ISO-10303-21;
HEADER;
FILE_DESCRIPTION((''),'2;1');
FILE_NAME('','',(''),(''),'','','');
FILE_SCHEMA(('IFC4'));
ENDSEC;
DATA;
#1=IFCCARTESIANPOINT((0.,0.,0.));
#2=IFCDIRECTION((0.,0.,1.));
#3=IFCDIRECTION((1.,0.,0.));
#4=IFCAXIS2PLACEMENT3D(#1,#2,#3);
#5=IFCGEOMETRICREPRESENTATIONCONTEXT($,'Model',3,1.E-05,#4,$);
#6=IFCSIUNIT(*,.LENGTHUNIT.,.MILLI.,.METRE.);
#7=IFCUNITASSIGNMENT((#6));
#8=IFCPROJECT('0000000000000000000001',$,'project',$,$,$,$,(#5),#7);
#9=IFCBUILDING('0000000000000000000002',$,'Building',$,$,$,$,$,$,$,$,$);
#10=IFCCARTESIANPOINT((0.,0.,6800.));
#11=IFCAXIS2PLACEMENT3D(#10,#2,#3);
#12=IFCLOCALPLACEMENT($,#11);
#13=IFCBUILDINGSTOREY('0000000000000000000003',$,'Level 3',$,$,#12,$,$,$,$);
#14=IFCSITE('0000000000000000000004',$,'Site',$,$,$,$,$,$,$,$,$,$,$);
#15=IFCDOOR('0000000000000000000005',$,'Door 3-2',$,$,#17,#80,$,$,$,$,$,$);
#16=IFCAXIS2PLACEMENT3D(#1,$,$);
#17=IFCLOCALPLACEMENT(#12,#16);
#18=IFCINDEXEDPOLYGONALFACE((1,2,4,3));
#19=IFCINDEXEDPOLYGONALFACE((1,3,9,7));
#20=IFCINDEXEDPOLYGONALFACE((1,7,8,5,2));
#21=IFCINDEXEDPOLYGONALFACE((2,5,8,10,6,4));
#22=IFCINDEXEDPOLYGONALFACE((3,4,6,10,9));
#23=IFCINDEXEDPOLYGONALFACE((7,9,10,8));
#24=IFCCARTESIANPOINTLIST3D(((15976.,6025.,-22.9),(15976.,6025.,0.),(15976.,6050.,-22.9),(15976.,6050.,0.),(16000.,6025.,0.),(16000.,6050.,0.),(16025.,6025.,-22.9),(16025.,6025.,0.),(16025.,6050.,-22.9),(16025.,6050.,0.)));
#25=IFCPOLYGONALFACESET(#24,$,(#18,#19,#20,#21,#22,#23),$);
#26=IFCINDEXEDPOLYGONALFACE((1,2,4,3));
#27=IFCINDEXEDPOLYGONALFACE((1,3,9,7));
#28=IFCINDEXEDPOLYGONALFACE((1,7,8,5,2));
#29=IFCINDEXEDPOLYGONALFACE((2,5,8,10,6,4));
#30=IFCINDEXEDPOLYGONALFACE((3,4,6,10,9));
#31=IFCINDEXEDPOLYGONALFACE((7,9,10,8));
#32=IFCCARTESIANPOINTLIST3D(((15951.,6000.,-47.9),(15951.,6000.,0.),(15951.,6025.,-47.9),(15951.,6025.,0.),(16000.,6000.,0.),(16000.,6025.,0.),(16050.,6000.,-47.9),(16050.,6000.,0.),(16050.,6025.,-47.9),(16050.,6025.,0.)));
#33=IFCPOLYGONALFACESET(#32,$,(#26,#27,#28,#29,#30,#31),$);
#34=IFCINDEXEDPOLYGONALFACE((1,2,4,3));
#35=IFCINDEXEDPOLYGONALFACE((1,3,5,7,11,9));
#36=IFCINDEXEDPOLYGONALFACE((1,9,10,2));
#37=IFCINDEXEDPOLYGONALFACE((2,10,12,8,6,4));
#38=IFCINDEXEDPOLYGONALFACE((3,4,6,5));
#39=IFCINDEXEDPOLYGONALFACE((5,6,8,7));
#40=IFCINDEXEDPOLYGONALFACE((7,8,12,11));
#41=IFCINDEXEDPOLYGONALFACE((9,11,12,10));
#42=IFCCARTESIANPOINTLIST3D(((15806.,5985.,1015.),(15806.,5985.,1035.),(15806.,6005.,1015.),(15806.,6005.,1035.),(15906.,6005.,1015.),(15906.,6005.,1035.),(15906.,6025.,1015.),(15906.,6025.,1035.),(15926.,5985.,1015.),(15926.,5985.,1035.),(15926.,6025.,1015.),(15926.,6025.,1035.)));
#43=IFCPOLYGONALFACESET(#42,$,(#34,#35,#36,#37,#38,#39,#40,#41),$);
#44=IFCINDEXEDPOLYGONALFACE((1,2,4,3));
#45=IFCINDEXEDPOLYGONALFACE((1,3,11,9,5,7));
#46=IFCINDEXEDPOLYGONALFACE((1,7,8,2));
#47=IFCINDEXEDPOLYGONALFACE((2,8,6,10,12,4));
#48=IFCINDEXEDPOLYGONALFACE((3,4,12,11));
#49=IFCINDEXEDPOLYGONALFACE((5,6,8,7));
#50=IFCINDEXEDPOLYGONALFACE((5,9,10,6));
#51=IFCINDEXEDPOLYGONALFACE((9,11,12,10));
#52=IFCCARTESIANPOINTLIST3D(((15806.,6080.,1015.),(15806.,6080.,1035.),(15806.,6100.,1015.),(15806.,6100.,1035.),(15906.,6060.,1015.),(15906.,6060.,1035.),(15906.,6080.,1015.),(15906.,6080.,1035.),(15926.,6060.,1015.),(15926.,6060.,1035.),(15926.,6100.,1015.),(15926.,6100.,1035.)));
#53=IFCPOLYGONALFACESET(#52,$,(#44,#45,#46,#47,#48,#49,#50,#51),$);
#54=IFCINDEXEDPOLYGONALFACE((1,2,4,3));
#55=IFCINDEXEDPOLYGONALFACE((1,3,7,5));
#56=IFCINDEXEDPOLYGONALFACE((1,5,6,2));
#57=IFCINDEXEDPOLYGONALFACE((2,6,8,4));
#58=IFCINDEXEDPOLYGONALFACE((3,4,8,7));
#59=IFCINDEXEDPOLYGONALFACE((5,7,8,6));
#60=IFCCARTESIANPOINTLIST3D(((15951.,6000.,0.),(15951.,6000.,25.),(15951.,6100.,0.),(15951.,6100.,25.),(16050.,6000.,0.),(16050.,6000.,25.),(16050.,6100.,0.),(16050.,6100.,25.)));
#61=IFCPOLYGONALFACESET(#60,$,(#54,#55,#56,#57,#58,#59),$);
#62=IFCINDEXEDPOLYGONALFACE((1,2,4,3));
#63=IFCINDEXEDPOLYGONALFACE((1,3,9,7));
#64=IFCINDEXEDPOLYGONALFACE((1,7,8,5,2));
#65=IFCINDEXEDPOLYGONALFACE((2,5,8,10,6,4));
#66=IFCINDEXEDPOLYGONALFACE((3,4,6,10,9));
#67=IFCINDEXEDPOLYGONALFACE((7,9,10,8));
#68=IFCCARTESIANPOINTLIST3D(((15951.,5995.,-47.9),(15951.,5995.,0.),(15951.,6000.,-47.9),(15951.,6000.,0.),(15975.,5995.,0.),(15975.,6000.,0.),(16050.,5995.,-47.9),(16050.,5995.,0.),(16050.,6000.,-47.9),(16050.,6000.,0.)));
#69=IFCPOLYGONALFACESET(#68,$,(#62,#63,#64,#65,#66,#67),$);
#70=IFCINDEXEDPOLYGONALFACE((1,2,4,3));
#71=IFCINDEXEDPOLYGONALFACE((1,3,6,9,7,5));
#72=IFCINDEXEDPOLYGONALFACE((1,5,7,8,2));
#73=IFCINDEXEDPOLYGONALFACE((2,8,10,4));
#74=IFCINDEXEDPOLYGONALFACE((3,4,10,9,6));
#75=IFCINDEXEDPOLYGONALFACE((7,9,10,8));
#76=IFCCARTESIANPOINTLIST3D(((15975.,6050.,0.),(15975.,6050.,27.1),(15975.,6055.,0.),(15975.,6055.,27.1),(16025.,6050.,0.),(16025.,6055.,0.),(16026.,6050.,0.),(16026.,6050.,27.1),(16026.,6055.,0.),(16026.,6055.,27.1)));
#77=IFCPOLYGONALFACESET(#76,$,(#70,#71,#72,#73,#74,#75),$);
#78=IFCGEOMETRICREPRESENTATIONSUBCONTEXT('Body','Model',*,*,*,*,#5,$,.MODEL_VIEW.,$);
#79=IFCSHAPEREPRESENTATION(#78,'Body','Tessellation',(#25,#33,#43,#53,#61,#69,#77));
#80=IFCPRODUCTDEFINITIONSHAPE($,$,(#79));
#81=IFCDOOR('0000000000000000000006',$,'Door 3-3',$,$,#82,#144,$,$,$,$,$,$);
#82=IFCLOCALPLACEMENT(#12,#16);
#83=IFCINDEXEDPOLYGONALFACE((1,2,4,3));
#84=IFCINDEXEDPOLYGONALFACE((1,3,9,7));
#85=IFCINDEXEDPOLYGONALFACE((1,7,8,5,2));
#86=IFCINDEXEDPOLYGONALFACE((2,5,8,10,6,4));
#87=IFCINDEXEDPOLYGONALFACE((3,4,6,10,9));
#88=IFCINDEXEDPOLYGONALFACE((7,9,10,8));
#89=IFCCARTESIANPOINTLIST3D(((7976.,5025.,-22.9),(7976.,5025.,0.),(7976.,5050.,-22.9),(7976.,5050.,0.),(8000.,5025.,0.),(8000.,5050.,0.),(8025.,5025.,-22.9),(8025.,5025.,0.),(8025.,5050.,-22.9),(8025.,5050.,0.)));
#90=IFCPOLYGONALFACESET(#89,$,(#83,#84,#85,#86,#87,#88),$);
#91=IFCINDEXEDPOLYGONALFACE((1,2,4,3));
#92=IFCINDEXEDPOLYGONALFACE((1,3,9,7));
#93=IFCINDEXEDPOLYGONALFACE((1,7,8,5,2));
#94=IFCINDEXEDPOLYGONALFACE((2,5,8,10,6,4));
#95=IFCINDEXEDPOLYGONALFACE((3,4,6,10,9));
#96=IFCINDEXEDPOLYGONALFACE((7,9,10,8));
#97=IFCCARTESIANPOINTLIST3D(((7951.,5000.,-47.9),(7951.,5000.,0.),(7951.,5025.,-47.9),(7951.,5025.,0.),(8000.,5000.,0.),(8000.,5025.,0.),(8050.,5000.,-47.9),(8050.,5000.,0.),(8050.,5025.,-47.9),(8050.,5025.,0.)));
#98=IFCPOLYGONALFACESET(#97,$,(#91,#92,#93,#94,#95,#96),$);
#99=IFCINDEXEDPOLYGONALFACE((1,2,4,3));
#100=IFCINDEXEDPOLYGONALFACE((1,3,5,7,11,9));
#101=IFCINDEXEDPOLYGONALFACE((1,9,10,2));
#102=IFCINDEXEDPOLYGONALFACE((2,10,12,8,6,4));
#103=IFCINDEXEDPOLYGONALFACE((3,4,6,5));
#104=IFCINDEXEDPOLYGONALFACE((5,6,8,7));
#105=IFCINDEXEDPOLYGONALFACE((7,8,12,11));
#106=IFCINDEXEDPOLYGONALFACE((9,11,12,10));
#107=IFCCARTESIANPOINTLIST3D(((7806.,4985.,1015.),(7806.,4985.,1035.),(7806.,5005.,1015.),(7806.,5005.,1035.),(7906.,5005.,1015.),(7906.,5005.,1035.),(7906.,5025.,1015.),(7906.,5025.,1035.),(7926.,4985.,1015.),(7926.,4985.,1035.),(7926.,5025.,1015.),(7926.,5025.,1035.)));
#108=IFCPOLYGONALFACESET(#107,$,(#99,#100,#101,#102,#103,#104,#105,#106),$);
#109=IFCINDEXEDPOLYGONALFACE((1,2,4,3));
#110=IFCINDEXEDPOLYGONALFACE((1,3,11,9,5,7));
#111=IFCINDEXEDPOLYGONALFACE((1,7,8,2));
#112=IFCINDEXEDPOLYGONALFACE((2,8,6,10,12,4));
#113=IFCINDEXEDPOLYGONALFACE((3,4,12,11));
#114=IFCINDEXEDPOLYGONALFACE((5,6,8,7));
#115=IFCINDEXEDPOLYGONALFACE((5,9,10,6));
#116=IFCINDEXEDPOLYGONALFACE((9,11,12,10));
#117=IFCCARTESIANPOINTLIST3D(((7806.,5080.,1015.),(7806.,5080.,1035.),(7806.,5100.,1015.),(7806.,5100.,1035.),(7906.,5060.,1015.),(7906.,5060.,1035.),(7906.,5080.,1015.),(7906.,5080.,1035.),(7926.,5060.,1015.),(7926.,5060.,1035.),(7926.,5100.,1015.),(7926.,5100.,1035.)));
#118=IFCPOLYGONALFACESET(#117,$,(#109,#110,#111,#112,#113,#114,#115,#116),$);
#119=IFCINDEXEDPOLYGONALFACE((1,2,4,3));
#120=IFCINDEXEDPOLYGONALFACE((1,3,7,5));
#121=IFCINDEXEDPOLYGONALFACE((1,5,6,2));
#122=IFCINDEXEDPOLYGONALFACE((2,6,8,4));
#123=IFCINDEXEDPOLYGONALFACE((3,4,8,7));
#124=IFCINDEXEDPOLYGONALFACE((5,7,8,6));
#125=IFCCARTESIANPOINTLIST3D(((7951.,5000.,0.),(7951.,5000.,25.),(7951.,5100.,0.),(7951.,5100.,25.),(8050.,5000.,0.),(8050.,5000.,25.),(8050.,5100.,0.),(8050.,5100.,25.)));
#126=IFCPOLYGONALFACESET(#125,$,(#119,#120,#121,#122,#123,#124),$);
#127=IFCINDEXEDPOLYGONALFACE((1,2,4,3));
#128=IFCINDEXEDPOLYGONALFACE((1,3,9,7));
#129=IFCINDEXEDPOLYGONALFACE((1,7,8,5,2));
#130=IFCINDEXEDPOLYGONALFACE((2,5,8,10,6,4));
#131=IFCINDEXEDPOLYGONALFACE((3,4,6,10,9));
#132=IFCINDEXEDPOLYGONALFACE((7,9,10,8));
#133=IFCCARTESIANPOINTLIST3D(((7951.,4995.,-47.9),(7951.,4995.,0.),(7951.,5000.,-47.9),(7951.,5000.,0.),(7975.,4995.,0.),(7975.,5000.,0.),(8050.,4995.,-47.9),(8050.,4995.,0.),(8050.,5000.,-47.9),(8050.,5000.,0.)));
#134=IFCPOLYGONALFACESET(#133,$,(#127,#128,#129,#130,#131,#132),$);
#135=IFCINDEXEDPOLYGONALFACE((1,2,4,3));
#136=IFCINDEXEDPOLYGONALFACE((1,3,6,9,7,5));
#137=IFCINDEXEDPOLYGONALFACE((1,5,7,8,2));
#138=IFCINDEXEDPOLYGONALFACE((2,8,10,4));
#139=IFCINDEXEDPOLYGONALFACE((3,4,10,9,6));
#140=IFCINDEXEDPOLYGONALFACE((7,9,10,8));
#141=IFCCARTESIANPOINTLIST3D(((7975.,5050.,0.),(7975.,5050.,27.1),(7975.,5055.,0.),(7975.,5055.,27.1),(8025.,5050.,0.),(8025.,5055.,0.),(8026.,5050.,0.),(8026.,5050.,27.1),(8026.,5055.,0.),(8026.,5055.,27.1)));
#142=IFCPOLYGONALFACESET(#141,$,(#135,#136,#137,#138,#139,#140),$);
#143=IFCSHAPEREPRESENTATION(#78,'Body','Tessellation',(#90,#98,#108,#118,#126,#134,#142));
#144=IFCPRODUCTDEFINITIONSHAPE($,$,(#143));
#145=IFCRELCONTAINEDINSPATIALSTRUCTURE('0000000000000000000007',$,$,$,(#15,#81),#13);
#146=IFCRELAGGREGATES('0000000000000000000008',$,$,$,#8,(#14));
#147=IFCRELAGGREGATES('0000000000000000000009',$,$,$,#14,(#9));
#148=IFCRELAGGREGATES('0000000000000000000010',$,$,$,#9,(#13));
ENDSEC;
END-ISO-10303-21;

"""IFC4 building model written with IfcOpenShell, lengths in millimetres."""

from ifc_helpers import new_model, si_unit, frame, origin_with_axes, place, context, subcontext, project, spatial, line, indexed_curve, outline, extrude, element, save


model = new_model("IFC4")

# Units and contexts
model_context = context("Model", 3, precision=1e-05, world=origin_with_axes())
body_context = subcontext(model_context, "Body", "Model", "MODEL_VIEW")
ifc_project = project(units=[si_unit("LENGTHUNIT", "METRE", prefix="MILLI")], contexts=[model_context])

# Site, building, storey
site = spatial("IfcSite", under=ifc_project, Name="Site")
building = spatial("IfcBuilding", under=site, Name="Building")
storey_placement = place(None, frame((0.0, 0.0, 6800.0), z_axis=(0.0, 0.0, 1.0), x_axis=(1.0, 0.0, 0.0)))
storey = spatial("IfcBuildingStorey", under=building, at=storey_placement, Name="Level 3")

# Doors
door_1_placement = place(storey_placement, frame((16000.0, 6000.0, 0.0), z_axis=(0.0, 0.0, 1.0), x_axis=(1.0, 0.0, 0.0)))
element("IfcDoor", 1, at=door_1_placement, inside=storey, Name="Door 3-2", context=body_context, shape_type="SweptSolid", body=[
    extrude(outline(indexed_curve([(0.0, 0.0), (0.0, 2.1), (1.0, 2.1), (1.0, 0.0), (-24.0, 0.0), (-24.0, -22.9), (25.0, -22.9), (25.0, 0.0)], segments=[line(1, 2, 3, 4, 5, 6, 7, 8, 1)])), frame((0.0, 25.0, 0.0), z_axis=(0.0, -1.0, 0.0), x_axis=(1.0, 0.0, 0.0)), (0.0, 0.0, -1.0), 25.0),
    extrude(outline(indexed_curve([(0.0, 0.0), (0.0, 2.1), (1.0, 2.1), (1.0, 0.0), (-49.0, 0.0), (-49.0, -47.9), (50.0, -47.9), (50.0, 0.0)], segments=[line(1, 2, 3, 4, 5, 6, 7, 8, 1)])), frame((0.0, 0.0, 0.0), z_axis=(0.0, -1.0, 0.0), x_axis=(1.0, 0.0, 0.0)), (0.0, 0.0, -1.0), 25.0),
    extrude(outline(indexed_curve([(0.0, 0.0), (-49.0, 0.0), (-49.0, 35.0), (0.0, 35.0)], segments=[line(1, 2, 3, 4, 1)])), frame((25.0, 25.0, 25.0), z_axis=(0.0, 0.0, 1.0), x_axis=(1.0, 0.0, 0.0)), (0.0, 0.0, 1.0), -47.9),
    extrude(outline(indexed_curve([(0.0, 0.0), (0.0, -40.0), (-120.0, -40.0), (-120.0, -20.0), (-20.0, -20.0), (-20.0, 0.0)], segments=[line(1, 2, 3, 4, 5, 6, 1)])), frame((-74.0, 25.0, 1015.0), z_axis=(0.0, 0.0, 1.0), x_axis=(1.0, 0.0, 0.0)), (0.0, 0.0, 1.0), 20.0),
    extrude(outline(indexed_curve([(0.0, 0.0), (0.0, 40.0), (-120.0, 40.0), (-120.0, 20.0), (-20.0, 20.0), (-20.0, 0.0)], segments=[line(1, 2, 3, 4, 5, 6, 1)])), frame((-74.0, 60.0, 1015.0), z_axis=(0.0, 0.0, 1.0), x_axis=(1.0, 0.0, 0.0)), (0.0, 0.0, 1.0), 20.0),
    extrude(outline(indexed_curve([(0.0, 0.0), (-99.0, 0.0), (-99.0, 100.0), (0.0, 100.0)], segments=[line(1, 2, 3, 4, 1)])), frame((50.0, 0.0, 0.0), z_axis=(0.0, 0.0, 1.0), x_axis=(1.0, 0.0, 0.0)), (0.0, 0.0, 1.0), 25.0),
    extrude(outline(indexed_curve([(0.0, 0.0), (0.0, 27.1), (51.0, 27.1), (51.0, 0.0), (-24.0, 0.0), (-24.0, -47.9), (75.0, -47.9), (75.0, 0.0)], segments=[line(1, 2, 3, 4, 5, 6, 7, 8, 1)])), frame((-25.0, -5.0, 0.0), z_axis=(0.0, -1.0, 0.0), x_axis=(1.0, 0.0, 0.0)), (0.0, 0.0, -1.0), 5.0),
    extrude(outline(indexed_curve([(0.0, 0.0), (0.0, 27.1), (51.0, 27.1), (51.0, 0.0), (1.0, 0.0), (1.0, -22.9), (50.0, -22.9), (50.0, 0.0)], segments=[line(1, 2, 3, 4, 5, 6, 7, 8, 1)])), frame((-25.0, 50.0, 0.0), z_axis=(0.0, -1.0, 0.0), x_axis=(1.0, 0.0, 0.0)), (0.0, 0.0, -1.0), 5.0),
])
door_2_placement = place(storey_placement, frame((8000.0, 5000.0, 0.0), z_axis=(0.0, 0.0, 1.0), x_axis=(1.0, 0.0, 0.0)))
element("IfcDoor", 2, at=door_2_placement, inside=storey, Name="Door 3-3", context=body_context, shape_type="SweptSolid", body=[
    extrude(outline(indexed_curve([(0.0, 0.0), (0.0, 2.1), (1.0, 2.1), (1.0, 0.0), (-24.0, 0.0), (-24.0, -22.9), (25.0, -22.9), (25.0, 0.0)], segments=[line(1, 2, 3, 4, 5, 6, 7, 8, 1)])), frame((0.0, 25.0, 0.0), z_axis=(0.0, -1.0, 0.0), x_axis=(1.0, 0.0, 0.0)), (0.0, 0.0, -1.0), 25.0),
    extrude(outline(indexed_curve([(0.0, 0.0), (0.0, 2.1), (1.0, 2.1), (1.0, 0.0), (-49.0, 0.0), (-49.0, -47.9), (50.0, -47.9), (50.0, 0.0)], segments=[line(1, 2, 3, 4, 5, 6, 7, 8, 1)])), frame((0.0, 0.0, 0.0), z_axis=(0.0, -1.0, 0.0), x_axis=(1.0, 0.0, 0.0)), (0.0, 0.0, -1.0), 25.0),
    extrude(outline(indexed_curve([(0.0, 0.0), (-49.0, 0.0), (-49.0, 35.0), (0.0, 35.0)], segments=[line(1, 2, 3, 4, 1)])), frame((25.0, 25.0, 25.0), z_axis=(0.0, 0.0, 1.0), x_axis=(1.0, 0.0, 0.0)), (0.0, 0.0, 1.0), -47.9),
    extrude(outline(indexed_curve([(0.0, 0.0), (0.0, -40.0), (-120.0, -40.0), (-120.0, -20.0), (-20.0, -20.0), (-20.0, 0.0)], segments=[line(1, 2, 3, 4, 5, 6, 1)])), frame((-74.0, 25.0, 1015.0), z_axis=(0.0, 0.0, 1.0), x_axis=(1.0, 0.0, 0.0)), (0.0, 0.0, 1.0), 20.0),
    extrude(outline(indexed_curve([(0.0, 0.0), (0.0, 40.0), (-120.0, 40.0), (-120.0, 20.0), (-20.0, 20.0), (-20.0, 0.0)], segments=[line(1, 2, 3, 4, 5, 6, 1)])), frame((-74.0, 60.0, 1015.0), z_axis=(0.0, 0.0, 1.0), x_axis=(1.0, 0.0, 0.0)), (0.0, 0.0, 1.0), 20.0),
    extrude(outline(indexed_curve([(0.0, 0.0), (-99.0, 0.0), (-99.0, 100.0), (0.0, 100.0)], segments=[line(1, 2, 3, 4, 1)])), frame((50.0, 0.0, 0.0), z_axis=(0.0, 0.0, 1.0), x_axis=(1.0, 0.0, 0.0)), (0.0, 0.0, 1.0), 25.0),
    extrude(outline(indexed_curve([(0.0, 0.0), (0.0, 27.1), (51.0, 27.1), (51.0, 0.0), (-24.0, 0.0), (-24.0, -47.9), (75.0, -47.9), (75.0, 0.0)], segments=[line(1, 2, 3, 4, 5, 6, 7, 8, 1)])), frame((-25.0, -5.0, 0.0), z_axis=(0.0, -1.0, 0.0), x_axis=(1.0, 0.0, 0.0)), (0.0, 0.0, -1.0), 5.0),
    extrude(outline(indexed_curve([(0.0, 0.0), (0.0, 27.1), (51.0, 27.1), (51.0, 0.0), (1.0, 0.0), (1.0, -22.9), (50.0, -22.9), (50.0, 0.0)], segments=[line(1, 2, 3, 4, 5, 6, 7, 8, 1)])), frame((-25.0, 50.0, 0.0), z_axis=(0.0, -1.0, 0.0), x_axis=(1.0, 0.0, 0.0)), (0.0, 0.0, -1.0), 5.0),
])

save(model, "model.ifc")
